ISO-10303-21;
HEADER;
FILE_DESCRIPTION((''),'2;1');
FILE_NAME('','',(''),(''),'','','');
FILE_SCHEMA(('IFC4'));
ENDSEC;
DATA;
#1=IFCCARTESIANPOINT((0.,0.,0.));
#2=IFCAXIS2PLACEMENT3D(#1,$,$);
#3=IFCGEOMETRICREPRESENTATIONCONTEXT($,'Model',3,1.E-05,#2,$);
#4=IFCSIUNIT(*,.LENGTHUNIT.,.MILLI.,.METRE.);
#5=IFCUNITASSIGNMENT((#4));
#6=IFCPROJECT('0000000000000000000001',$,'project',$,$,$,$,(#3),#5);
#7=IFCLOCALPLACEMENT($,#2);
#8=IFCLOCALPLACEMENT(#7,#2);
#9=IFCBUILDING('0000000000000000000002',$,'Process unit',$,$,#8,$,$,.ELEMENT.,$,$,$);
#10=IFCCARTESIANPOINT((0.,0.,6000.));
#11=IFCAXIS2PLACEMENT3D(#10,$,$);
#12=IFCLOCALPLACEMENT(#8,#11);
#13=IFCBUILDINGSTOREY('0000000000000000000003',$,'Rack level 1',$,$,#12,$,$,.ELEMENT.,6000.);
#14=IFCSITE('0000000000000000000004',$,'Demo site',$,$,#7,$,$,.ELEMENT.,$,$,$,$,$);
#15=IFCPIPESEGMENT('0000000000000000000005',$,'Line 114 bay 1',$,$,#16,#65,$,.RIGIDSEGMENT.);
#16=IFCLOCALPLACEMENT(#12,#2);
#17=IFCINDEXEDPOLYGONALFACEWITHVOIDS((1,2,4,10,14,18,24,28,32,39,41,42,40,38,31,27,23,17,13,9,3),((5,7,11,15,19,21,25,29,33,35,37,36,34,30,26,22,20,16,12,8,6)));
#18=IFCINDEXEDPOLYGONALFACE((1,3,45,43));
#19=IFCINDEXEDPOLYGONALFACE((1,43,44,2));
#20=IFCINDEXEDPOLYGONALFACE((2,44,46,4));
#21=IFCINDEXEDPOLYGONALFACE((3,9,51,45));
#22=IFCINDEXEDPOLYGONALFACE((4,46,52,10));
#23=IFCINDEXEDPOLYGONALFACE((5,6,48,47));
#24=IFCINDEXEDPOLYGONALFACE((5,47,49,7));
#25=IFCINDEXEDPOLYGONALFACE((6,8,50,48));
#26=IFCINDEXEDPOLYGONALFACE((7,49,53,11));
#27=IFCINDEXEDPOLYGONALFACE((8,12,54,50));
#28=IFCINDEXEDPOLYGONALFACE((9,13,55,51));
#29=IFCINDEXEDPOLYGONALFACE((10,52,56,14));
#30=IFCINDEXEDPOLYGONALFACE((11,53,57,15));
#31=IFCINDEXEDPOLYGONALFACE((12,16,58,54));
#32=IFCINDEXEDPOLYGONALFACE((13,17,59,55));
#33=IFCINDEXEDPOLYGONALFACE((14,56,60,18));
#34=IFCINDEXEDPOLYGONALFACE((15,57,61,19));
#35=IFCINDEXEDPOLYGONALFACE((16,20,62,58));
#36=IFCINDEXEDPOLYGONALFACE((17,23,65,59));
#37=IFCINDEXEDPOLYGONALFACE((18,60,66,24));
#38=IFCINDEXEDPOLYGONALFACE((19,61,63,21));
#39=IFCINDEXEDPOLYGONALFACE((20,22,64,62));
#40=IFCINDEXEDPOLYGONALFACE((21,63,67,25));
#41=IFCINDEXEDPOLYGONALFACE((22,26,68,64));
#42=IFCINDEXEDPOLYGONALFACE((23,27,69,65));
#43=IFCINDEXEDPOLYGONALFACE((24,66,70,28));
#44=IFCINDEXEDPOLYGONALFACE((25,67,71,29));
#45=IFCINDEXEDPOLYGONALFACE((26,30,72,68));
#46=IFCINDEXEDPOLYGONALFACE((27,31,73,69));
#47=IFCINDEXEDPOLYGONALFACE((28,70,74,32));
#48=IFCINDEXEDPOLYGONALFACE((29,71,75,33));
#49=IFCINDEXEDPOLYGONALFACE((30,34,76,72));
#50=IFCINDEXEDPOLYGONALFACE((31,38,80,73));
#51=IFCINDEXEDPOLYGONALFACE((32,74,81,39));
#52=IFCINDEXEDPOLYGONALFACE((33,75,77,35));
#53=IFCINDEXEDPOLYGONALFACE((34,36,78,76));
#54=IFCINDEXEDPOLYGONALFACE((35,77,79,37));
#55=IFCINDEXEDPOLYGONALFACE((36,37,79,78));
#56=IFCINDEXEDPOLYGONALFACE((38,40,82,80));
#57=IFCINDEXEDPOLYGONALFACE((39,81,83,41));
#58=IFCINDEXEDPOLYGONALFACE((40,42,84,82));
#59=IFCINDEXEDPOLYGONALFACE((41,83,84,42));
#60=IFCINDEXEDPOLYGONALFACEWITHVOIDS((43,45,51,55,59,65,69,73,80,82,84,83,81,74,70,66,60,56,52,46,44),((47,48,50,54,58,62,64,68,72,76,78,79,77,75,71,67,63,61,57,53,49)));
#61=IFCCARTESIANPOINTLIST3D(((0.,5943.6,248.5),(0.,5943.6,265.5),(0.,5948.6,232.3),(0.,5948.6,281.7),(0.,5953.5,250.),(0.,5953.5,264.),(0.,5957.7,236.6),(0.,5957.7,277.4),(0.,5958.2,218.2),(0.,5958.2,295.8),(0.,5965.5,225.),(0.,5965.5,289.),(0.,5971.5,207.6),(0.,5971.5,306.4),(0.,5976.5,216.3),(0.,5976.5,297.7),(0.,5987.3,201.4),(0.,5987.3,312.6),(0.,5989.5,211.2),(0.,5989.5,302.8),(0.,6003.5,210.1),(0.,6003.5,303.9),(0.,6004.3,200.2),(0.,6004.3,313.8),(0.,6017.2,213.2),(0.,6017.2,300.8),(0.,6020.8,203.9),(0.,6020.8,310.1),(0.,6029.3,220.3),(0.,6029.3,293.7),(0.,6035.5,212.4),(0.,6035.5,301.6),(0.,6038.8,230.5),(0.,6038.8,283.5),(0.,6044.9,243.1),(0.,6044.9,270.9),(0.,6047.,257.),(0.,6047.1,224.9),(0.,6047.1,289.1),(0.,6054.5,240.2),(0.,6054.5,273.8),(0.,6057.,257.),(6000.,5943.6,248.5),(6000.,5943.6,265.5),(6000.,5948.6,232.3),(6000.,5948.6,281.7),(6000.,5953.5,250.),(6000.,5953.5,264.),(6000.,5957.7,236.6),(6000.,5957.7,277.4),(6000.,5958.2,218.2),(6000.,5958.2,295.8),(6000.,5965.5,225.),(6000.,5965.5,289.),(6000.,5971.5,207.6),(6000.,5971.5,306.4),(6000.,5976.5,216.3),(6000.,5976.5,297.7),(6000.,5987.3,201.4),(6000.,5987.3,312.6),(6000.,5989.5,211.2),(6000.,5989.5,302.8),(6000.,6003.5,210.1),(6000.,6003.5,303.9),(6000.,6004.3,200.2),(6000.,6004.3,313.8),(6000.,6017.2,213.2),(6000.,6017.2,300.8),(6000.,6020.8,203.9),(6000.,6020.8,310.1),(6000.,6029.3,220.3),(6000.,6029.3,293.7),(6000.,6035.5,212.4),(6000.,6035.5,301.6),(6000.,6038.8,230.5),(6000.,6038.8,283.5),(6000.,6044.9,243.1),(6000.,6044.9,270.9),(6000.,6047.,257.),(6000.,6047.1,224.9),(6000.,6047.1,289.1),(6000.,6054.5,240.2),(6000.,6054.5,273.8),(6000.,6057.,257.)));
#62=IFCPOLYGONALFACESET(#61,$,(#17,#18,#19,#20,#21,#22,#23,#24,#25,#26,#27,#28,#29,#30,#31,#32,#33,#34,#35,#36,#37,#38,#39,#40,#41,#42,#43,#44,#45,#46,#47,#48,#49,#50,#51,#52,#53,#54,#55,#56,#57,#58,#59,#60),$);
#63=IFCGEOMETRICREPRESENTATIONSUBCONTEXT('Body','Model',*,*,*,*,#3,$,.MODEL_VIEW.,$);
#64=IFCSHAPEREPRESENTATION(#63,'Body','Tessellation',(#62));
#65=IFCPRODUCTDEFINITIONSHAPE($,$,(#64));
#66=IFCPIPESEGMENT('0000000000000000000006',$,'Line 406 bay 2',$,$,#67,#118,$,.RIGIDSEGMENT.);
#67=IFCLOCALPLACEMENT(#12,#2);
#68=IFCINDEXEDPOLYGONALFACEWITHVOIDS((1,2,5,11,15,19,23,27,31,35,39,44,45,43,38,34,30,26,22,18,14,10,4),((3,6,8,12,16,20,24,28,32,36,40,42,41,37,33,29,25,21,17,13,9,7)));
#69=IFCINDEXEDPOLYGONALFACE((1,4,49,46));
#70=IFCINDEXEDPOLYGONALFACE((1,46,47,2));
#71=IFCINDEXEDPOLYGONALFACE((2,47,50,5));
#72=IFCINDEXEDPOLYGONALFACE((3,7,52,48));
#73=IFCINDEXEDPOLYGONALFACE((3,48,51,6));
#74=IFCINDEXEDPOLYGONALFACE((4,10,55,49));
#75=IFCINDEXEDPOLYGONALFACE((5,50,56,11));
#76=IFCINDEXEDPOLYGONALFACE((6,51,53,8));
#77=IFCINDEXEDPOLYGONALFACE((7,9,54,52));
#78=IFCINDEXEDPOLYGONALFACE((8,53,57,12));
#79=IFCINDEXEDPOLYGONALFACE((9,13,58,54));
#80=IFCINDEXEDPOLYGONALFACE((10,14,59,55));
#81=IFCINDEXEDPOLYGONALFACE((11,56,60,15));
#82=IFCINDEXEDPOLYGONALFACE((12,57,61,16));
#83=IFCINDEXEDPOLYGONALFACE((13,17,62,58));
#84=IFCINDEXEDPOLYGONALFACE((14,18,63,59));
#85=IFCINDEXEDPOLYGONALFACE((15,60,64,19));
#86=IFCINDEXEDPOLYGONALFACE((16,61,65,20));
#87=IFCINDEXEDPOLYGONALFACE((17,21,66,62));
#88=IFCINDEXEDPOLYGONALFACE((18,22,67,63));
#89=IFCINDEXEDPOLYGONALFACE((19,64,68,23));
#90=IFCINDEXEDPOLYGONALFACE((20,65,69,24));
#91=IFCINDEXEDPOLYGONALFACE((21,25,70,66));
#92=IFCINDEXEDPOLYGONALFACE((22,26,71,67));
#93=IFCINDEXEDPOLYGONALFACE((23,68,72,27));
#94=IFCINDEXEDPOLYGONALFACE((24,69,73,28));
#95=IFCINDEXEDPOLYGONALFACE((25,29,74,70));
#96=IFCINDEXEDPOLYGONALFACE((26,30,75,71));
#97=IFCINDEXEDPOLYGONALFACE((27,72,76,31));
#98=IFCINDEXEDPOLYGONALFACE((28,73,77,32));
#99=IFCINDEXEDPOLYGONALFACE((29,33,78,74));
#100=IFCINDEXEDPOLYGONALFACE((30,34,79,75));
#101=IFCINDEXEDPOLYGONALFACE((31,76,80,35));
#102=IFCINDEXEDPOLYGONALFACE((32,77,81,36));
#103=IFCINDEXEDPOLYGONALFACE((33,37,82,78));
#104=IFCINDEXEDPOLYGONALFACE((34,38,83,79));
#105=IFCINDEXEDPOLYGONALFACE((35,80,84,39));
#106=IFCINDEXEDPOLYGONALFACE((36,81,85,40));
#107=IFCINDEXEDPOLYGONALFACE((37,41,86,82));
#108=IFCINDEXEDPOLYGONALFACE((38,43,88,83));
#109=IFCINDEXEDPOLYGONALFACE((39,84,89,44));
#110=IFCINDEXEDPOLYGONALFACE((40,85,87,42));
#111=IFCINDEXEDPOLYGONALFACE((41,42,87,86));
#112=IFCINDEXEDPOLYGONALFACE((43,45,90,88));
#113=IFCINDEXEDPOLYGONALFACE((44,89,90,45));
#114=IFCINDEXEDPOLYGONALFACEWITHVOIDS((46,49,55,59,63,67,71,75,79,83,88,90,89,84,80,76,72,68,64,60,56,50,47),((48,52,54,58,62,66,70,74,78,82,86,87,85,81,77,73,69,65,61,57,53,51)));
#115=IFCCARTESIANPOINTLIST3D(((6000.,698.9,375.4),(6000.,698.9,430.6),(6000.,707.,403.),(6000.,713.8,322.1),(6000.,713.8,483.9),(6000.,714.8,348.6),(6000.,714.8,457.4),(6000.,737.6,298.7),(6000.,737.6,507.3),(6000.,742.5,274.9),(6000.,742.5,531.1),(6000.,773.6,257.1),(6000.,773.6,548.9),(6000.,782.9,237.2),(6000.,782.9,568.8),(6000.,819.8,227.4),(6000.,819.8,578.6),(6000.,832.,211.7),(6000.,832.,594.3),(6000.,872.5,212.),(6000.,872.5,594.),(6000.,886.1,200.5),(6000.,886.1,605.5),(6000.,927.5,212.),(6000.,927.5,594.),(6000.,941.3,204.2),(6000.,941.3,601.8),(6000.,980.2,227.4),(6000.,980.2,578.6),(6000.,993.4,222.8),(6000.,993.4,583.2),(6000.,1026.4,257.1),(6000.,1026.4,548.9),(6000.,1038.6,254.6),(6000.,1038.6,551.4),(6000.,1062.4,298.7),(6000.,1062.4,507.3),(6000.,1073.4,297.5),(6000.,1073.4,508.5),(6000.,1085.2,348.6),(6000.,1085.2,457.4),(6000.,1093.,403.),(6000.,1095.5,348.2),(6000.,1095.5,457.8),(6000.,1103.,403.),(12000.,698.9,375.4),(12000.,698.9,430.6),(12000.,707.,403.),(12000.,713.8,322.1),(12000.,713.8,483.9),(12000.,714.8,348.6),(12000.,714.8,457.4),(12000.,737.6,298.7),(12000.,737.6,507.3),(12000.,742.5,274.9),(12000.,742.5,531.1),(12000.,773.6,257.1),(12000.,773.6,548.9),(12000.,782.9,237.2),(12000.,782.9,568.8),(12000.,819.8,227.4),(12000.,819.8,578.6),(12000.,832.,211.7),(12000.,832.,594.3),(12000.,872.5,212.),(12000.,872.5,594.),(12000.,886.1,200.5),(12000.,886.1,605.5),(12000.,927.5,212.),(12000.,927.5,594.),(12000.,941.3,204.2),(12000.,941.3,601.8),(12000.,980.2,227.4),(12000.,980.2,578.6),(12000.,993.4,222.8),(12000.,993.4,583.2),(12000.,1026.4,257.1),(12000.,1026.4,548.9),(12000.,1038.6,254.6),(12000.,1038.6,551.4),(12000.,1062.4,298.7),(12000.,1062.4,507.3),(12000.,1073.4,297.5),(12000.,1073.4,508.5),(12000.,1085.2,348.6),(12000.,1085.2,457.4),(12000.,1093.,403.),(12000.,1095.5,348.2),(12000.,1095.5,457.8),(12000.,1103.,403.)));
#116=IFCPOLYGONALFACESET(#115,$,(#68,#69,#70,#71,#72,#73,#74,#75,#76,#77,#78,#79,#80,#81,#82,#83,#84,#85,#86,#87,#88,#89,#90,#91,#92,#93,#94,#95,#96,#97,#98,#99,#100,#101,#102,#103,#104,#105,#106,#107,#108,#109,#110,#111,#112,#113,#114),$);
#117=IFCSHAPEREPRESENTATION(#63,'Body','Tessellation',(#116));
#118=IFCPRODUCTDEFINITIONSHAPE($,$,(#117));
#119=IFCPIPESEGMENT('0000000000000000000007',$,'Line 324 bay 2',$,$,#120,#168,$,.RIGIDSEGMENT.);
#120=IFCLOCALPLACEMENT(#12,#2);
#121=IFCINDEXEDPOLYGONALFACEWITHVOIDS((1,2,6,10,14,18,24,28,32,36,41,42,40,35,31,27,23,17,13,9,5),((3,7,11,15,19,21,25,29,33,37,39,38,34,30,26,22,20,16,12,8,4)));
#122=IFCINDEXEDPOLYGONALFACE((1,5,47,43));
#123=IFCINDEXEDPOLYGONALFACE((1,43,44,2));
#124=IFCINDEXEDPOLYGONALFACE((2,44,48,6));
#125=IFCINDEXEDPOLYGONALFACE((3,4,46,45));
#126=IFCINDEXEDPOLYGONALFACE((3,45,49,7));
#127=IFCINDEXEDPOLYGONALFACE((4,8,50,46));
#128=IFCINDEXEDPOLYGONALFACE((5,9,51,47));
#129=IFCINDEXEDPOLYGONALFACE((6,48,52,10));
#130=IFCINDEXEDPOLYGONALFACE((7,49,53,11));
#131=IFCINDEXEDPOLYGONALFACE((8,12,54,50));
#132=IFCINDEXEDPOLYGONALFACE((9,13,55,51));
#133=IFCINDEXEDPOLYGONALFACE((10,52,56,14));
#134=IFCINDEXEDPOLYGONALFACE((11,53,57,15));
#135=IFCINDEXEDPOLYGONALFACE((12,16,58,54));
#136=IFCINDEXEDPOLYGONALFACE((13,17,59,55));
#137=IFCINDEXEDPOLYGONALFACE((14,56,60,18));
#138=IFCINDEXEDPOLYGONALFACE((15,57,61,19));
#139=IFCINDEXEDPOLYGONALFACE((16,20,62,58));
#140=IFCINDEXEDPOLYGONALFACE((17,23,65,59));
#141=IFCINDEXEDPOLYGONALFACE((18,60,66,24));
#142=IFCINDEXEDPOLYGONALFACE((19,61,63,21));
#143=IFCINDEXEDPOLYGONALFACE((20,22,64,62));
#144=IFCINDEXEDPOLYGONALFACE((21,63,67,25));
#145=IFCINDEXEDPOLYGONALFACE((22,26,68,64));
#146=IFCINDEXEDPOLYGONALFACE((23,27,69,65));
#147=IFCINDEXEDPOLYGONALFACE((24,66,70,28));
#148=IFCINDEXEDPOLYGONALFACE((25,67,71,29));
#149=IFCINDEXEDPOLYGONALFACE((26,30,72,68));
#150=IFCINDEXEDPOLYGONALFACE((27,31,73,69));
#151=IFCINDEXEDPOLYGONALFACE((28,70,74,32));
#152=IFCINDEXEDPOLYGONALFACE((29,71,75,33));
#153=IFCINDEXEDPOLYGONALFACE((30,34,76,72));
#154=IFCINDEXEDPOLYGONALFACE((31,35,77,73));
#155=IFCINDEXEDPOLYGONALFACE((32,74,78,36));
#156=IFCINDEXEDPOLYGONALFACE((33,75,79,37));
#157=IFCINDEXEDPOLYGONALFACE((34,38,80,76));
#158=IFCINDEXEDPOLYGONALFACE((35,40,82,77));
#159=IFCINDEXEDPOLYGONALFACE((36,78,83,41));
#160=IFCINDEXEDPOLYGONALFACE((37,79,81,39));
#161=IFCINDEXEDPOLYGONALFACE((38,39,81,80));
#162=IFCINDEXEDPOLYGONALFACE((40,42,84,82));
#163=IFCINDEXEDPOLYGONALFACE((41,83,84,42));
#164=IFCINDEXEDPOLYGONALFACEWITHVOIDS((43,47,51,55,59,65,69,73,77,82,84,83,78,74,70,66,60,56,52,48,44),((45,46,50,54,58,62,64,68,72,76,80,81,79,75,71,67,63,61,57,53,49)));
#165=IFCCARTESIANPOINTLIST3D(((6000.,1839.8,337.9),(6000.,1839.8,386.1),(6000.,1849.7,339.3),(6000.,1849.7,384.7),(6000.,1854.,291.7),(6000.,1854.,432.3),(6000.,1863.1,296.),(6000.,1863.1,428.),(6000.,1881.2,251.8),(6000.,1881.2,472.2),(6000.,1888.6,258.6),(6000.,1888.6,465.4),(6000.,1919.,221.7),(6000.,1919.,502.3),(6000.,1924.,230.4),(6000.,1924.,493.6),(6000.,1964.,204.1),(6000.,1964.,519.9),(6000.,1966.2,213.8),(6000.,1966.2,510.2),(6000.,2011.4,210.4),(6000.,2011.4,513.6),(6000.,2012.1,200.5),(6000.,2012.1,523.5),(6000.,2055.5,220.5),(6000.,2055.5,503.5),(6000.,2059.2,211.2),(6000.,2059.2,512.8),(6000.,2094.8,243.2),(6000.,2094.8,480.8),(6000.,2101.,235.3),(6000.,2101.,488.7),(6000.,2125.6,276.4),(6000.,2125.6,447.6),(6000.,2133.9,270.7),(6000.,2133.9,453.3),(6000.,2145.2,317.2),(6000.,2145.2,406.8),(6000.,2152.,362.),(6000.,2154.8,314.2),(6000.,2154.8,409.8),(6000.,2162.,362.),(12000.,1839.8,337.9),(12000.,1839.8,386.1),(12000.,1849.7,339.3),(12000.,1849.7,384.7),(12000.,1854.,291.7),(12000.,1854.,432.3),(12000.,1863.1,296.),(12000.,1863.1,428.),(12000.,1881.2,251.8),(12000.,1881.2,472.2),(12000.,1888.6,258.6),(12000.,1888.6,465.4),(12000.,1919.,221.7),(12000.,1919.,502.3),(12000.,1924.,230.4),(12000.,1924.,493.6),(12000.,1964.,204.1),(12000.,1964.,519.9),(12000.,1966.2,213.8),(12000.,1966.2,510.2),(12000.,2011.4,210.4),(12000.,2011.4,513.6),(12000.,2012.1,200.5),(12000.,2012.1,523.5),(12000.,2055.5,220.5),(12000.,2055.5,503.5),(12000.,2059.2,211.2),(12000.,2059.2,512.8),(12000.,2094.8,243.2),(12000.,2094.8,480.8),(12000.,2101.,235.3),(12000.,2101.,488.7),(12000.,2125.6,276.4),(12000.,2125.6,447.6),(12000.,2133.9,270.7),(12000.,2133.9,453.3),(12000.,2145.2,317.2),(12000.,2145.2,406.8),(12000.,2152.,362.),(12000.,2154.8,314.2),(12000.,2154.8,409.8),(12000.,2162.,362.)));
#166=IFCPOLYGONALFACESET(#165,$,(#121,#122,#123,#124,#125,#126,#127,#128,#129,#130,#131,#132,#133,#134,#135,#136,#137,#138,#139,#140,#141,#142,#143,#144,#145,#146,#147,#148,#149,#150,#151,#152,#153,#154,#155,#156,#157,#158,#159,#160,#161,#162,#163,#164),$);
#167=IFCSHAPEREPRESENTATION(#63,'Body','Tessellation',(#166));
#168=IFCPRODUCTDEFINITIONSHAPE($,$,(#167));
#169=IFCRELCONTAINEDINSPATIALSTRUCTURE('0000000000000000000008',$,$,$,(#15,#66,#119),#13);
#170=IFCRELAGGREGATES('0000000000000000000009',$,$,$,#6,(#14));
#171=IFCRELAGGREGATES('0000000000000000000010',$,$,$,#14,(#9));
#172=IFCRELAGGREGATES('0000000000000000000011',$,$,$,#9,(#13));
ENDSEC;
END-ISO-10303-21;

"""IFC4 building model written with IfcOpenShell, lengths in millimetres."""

from ifc_helpers import new_model, si_unit, frame, origin, place, context, subcontext, project, spatial, hollow_circle, extrude, element, save


model = new_model("IFC4")

# Units and contexts
model_context = context("Model", 3, precision=1e-05, world=origin())
body_context = subcontext(model_context, "Body", "Model", "MODEL_VIEW")
ifc_project = project(units=[si_unit("LENGTHUNIT", "METRE", prefix="MILLI")], contexts=[model_context])

# Site, building, storey
site_placement = place(None, origin())
site = spatial("IfcSite", under=ifc_project, at=site_placement, Name="Demo site", CompositionType="ELEMENT")
building_placement = place(site_placement, origin())
building = spatial("IfcBuilding", under=site, at=building_placement, Name="Process unit", CompositionType="ELEMENT")
storey_placement = place(building_placement, frame((0.0, 0.0, 6000.0)))
storey = spatial("IfcBuildingStorey", under=building, at=storey_placement, Name="Rack level 1", CompositionType="ELEMENT", Elevation=6000.0)

# Pipe segments
pipe_segment_1_placement = place(storey_placement, frame((0.0, 6000.0, 257.0)))
element("IfcPipeSegment", 1, at=pipe_segment_1_placement, inside=storey, Name="Line 114 bay 1", PredefinedType="RIGIDSEGMENT", context=body_context, shape_type="SweptSolid", body=[
    extrude(hollow_circle(Radius=57.0, WallThickness=10.0), frame((0.0, 0.0, 0.0), z_axis=(1.0, 0.0, 0.0), x_axis=(0.0, 1.0, 0.0)), (0.0, 0.0, 1.0), 6000.0),
])
pipe_segment_2_placement = place(storey_placement, frame((6000.0, 900.0, 403.0)))
element("IfcPipeSegment", 2, at=pipe_segment_2_placement, inside=storey, Name="Line 406 bay 2", PredefinedType="RIGIDSEGMENT", context=body_context, shape_type="SweptSolid", body=[
    extrude(hollow_circle(Radius=203.0, WallThickness=10.0), frame((0.0, 0.0, 0.0), z_axis=(1.0, 0.0, 0.0), x_axis=(0.0, 1.0, 0.0)), (0.0, 0.0, 1.0), 6000.0),
])
pipe_segment_3_placement = place(storey_placement, frame((6000.0, 2000.0, 362.0)))
element("IfcPipeSegment", 3, at=pipe_segment_3_placement, inside=storey, Name="Line 324 bay 2", PredefinedType="RIGIDSEGMENT", context=body_context, shape_type="SweptSolid", body=[
    extrude(hollow_circle(Radius=162.0, WallThickness=10.0), frame((0.0, 0.0, 0.0), z_axis=(1.0, 0.0, 0.0), x_axis=(0.0, 1.0, 0.0)), (0.0, 0.0, 1.0), 6000.0),
])

save(model, "model.ifc")
